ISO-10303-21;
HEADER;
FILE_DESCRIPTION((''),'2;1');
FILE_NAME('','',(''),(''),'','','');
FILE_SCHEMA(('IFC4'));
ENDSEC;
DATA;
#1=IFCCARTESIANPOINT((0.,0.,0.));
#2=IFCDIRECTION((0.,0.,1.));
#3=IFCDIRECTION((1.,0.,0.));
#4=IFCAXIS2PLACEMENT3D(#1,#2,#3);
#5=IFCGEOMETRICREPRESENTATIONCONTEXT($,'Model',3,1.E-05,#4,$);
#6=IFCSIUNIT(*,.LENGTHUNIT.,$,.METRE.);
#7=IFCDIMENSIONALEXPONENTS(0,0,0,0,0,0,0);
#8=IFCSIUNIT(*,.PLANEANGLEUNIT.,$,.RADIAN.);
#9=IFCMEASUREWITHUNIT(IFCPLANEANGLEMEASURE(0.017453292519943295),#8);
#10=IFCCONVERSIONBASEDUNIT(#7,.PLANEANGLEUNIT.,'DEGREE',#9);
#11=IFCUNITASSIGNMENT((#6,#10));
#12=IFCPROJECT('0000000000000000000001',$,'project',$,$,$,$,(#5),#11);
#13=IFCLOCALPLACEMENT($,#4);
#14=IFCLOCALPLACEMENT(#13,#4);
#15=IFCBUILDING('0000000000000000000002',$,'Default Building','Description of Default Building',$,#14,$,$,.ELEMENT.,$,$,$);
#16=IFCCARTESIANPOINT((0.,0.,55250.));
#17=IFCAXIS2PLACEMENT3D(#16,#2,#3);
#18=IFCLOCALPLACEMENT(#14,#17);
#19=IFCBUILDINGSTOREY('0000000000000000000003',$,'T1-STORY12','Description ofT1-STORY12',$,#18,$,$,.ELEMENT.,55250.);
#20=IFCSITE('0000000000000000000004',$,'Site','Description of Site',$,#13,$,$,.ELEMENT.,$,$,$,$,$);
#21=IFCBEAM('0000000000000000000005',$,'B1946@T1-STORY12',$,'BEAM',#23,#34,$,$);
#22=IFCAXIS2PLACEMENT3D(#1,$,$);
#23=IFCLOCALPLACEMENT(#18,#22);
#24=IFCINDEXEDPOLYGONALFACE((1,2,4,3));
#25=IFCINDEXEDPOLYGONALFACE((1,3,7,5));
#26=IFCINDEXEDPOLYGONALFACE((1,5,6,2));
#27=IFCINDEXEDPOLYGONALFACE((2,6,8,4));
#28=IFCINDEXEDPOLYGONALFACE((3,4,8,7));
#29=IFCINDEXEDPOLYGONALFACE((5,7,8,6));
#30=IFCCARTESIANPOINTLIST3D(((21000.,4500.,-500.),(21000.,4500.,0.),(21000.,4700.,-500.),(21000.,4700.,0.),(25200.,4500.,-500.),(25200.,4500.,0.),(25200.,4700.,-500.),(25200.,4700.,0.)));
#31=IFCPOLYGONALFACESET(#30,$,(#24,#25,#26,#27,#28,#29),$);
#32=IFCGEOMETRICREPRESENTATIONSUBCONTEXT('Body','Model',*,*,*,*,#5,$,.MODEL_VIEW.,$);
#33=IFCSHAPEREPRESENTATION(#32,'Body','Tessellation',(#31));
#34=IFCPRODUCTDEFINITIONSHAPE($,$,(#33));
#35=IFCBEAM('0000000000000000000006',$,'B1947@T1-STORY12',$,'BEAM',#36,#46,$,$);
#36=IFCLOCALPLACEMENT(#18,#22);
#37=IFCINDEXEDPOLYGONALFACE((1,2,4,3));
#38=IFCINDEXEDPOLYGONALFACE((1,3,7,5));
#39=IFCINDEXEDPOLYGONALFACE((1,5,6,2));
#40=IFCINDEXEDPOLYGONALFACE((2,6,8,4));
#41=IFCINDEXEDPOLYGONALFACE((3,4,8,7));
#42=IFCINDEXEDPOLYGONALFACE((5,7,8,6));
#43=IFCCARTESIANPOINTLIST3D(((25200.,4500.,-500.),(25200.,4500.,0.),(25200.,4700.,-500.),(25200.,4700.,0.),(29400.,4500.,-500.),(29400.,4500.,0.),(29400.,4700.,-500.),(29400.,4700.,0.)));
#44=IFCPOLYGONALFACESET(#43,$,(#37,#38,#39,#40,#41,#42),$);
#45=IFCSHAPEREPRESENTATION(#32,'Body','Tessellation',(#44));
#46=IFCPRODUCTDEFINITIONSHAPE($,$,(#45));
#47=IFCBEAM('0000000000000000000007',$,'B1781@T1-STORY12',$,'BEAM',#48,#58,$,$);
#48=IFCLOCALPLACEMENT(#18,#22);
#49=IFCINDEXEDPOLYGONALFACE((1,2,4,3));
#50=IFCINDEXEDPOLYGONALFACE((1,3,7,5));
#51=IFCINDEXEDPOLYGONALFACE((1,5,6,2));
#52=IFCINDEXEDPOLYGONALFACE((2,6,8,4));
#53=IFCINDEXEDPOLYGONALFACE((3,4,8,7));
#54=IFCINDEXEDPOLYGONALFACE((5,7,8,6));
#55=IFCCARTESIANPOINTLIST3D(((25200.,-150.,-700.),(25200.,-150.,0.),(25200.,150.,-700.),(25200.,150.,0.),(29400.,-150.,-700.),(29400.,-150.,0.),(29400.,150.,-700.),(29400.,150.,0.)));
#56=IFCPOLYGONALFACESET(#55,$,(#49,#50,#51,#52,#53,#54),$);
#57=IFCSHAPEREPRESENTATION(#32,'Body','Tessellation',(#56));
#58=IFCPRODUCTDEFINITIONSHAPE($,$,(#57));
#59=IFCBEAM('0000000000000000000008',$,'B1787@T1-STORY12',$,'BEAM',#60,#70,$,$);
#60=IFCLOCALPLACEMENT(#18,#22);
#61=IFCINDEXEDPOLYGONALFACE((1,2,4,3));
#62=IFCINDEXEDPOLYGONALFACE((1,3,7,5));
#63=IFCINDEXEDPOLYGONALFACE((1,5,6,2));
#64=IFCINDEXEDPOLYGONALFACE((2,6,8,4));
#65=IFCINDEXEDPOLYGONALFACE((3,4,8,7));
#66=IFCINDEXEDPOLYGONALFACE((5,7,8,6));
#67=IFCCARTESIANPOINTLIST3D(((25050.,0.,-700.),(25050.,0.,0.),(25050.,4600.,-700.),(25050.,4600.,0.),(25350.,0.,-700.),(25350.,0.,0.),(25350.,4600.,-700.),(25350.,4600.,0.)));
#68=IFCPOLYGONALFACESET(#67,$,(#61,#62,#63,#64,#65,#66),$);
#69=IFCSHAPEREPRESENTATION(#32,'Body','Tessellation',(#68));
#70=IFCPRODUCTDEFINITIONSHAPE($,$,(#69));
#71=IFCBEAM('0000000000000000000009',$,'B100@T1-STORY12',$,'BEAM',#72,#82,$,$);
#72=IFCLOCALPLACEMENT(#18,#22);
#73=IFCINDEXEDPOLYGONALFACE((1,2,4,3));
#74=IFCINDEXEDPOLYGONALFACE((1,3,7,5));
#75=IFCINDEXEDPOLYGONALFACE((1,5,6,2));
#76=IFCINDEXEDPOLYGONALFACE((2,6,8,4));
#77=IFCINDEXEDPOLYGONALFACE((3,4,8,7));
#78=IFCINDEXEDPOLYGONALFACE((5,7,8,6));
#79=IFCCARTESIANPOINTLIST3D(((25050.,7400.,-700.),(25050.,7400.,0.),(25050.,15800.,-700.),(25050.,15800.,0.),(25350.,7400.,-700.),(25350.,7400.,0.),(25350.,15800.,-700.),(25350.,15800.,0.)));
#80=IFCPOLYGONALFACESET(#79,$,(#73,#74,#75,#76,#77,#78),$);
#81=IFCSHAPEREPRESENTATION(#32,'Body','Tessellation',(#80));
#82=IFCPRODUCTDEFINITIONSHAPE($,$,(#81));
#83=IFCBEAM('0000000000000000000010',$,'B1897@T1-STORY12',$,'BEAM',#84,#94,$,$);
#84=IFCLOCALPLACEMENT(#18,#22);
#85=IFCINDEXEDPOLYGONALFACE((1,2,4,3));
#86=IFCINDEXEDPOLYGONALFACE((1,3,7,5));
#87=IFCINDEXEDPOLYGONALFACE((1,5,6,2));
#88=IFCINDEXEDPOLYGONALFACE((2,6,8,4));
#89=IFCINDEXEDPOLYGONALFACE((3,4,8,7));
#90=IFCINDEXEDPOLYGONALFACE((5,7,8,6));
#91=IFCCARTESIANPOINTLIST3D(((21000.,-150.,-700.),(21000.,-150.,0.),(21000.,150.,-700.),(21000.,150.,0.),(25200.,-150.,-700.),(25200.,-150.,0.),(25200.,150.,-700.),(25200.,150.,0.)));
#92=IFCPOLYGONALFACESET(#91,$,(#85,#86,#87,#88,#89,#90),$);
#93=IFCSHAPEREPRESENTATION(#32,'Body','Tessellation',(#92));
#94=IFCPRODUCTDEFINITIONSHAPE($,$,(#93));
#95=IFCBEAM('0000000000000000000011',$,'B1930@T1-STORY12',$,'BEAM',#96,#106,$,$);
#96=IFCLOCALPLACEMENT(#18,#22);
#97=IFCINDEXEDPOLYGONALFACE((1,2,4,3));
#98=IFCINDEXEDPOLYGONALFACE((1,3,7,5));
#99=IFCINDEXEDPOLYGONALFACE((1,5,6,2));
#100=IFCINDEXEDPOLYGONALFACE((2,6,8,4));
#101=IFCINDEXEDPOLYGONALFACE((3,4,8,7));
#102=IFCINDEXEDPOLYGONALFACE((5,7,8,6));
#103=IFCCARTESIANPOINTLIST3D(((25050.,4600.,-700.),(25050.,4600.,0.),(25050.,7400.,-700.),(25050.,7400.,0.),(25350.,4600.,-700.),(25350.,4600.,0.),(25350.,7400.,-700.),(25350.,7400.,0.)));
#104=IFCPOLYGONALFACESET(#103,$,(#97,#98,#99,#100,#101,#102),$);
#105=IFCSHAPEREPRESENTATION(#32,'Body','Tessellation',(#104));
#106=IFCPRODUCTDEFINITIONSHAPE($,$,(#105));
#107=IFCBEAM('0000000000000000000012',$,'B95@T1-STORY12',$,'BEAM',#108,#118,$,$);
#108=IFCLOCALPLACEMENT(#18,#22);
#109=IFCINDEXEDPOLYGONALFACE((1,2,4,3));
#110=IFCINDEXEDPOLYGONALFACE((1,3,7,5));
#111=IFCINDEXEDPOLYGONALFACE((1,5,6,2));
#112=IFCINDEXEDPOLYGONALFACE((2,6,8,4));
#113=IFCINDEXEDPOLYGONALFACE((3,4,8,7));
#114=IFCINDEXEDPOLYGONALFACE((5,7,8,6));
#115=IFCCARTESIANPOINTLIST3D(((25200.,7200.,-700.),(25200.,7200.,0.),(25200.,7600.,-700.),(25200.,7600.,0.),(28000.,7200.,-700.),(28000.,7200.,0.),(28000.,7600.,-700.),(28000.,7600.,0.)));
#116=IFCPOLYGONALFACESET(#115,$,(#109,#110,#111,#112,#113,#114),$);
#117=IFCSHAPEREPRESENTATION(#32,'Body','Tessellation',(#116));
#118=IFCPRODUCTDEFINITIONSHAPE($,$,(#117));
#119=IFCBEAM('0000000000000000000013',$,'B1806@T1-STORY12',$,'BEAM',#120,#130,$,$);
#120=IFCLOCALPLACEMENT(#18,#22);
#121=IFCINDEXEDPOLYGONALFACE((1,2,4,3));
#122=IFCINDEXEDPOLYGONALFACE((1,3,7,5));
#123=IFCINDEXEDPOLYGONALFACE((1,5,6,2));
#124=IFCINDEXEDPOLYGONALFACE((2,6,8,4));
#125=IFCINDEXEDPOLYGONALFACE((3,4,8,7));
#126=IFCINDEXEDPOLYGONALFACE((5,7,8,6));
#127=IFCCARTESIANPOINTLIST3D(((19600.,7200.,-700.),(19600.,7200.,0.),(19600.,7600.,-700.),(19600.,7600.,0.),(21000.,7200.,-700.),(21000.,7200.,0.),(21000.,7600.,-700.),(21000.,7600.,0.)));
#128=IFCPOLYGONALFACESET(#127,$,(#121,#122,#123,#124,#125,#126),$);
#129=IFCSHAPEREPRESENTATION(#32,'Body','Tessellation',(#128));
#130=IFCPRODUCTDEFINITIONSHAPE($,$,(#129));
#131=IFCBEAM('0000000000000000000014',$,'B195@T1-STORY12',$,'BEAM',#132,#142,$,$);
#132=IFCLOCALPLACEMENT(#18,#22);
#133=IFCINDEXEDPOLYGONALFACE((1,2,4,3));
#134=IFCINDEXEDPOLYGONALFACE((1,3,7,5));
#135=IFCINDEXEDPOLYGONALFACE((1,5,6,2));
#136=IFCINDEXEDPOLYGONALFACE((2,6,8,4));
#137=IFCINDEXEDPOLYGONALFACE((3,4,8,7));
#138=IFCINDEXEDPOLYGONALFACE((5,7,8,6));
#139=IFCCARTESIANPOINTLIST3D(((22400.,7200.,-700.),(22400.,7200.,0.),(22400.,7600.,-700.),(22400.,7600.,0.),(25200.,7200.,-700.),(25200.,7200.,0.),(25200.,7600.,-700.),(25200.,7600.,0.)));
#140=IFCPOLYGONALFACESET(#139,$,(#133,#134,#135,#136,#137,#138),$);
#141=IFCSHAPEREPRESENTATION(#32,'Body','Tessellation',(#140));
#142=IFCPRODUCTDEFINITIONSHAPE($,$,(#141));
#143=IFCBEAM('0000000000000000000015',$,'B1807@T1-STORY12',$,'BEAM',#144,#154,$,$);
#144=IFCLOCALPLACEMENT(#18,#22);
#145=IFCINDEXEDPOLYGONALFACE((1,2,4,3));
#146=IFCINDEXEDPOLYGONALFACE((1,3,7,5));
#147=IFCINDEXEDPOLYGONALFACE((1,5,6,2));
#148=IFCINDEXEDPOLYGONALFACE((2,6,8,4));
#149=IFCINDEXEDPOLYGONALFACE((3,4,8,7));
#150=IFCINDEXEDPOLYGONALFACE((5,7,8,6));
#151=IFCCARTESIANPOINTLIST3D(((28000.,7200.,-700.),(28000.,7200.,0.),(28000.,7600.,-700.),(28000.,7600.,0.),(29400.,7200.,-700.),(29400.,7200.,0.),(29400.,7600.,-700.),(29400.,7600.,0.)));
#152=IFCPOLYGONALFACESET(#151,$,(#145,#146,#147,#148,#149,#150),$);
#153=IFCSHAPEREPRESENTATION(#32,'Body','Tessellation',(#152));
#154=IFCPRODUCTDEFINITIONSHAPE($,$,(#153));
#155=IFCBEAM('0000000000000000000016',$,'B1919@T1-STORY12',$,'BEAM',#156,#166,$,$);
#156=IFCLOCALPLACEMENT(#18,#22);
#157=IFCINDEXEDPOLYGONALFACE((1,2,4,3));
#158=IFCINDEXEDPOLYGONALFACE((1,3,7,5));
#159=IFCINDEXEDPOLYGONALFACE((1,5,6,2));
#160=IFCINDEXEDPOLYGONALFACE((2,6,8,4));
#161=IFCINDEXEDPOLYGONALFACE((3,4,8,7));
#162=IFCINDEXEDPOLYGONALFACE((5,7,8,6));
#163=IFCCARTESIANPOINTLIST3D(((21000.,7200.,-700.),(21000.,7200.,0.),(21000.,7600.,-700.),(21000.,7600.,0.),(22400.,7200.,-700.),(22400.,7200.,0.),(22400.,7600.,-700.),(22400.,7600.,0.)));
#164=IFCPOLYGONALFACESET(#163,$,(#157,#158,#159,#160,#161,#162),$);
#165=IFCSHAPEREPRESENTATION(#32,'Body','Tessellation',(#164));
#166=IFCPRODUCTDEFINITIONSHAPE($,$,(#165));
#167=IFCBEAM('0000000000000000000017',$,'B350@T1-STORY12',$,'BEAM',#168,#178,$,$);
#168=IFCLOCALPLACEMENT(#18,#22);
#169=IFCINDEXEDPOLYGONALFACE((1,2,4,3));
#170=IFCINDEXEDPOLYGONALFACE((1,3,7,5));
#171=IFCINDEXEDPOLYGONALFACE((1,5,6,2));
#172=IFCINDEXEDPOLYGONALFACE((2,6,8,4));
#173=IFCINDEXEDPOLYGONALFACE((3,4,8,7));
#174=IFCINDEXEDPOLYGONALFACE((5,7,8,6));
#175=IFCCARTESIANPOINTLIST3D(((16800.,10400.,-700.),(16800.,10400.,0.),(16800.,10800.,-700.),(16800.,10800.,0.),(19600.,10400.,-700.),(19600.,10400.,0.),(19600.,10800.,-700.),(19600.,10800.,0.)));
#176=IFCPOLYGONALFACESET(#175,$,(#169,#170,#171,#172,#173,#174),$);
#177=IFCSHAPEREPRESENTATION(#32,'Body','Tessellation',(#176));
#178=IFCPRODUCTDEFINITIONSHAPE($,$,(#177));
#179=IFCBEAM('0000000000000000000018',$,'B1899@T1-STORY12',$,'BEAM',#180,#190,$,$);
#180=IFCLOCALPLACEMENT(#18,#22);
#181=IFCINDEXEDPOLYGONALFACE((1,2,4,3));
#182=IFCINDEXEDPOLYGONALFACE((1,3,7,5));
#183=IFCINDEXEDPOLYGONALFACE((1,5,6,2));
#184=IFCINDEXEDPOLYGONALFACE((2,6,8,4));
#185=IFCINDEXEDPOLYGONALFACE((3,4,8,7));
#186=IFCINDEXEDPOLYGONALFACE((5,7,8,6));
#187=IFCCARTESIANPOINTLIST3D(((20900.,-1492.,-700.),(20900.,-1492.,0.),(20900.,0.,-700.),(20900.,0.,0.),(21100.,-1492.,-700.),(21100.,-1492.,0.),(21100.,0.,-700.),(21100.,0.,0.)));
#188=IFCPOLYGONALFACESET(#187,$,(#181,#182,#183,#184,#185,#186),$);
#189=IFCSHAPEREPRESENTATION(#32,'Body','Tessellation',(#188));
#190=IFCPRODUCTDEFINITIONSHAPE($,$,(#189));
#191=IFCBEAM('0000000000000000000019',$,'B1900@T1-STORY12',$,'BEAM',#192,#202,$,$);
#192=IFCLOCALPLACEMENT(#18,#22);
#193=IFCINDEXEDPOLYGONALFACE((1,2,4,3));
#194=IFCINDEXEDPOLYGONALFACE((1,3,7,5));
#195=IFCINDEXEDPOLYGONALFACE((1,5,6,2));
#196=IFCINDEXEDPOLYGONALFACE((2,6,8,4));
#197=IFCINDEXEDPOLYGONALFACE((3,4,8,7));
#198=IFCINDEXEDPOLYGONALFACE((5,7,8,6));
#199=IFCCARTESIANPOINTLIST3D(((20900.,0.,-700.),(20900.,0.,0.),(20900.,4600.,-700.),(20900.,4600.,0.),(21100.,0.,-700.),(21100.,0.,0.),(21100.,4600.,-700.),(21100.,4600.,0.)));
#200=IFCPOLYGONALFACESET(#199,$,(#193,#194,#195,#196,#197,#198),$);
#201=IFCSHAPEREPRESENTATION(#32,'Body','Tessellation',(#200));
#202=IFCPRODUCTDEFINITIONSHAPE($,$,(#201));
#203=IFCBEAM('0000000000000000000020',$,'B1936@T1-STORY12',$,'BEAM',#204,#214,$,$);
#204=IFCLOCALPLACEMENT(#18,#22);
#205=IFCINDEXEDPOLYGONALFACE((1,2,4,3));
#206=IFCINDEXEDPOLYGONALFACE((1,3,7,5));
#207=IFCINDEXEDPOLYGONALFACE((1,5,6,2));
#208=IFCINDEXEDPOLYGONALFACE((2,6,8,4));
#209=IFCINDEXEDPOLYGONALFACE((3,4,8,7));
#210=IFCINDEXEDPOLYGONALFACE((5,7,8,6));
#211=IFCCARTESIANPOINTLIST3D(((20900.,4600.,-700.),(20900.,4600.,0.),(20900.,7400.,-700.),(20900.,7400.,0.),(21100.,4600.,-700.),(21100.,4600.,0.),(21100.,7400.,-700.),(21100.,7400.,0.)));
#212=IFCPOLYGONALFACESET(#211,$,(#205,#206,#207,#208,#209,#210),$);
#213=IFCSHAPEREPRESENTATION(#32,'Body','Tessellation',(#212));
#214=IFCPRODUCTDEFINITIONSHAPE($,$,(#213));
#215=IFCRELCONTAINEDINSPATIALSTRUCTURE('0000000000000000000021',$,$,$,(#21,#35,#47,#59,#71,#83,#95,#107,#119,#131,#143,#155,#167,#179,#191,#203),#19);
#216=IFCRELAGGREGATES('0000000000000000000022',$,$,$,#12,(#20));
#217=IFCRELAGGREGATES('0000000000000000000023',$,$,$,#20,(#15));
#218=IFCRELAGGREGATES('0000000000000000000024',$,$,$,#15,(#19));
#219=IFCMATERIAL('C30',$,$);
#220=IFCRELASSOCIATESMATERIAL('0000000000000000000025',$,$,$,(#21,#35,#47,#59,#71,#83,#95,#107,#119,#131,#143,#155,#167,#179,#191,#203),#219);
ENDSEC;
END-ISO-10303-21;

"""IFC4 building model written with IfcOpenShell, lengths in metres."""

from ifc_helpers import new_model, entity, si_unit, converted_unit, frame, origin_with_axes, place, context, subcontext, project, spatial, rectangle, extrude, material, element, save


model = new_model("IFC4")

# Units and contexts
model_context = context("Model", 3, precision=1e-05, world=origin_with_axes())
body_context = subcontext(model_context, "Body", "Model", "MODEL_VIEW")
ifc_project = project(units=[si_unit("LENGTHUNIT", "METRE"), converted_unit("PLANEANGLEUNIT", "DEGREE", entity("IfcPlaneAngleMeasure", 0.017453292519943295), si_unit("PLANEANGLEUNIT", "RADIAN"), dimensions=[0, 0, 0, 0, 0, 0, 0])], contexts=[model_context])

# Site, building, storey
site_placement = place(None, origin_with_axes())
site = spatial("IfcSite", under=ifc_project, at=site_placement, Name="Site", Description="Description of Site", CompositionType="ELEMENT")
building_placement = place(site_placement, origin_with_axes())
building = spatial("IfcBuilding", under=site, at=building_placement, Name="Default Building", Description="Description of Default Building", CompositionType="ELEMENT")
storey_placement = place(building_placement, frame((0.0, 0.0, 55250.0), z_axis=(0.0, 0.0, 1.0), x_axis=(1.0, 0.0, 0.0)))
storey = spatial("IfcBuildingStorey", under=building, at=storey_placement, Name="T1-STORY12", Description="Description ofT1-STORY12", CompositionType="ELEMENT", Elevation=55250.0)

# Beams
ifc_material_1 = material(Name="C30")
for number, where, z_axis, x_axis, name in (
    (1, (21000.0, 4600.0, -250.0), (1.0, 0.0, 0.0), (0.0, 1.0, 0.0), "B1946@T1-STORY12"),
    (2, (25200.0, 4600.0, -250.0), (1.0, 0.0, 0.0), (0.0, 1.0, 0.0), "B1947@T1-STORY12"),
):
    element("IfcBeam", number, at=place(storey_placement, frame(where, z_axis=z_axis, x_axis=x_axis)), inside=storey, material=ifc_material_1, Name=name, ObjectType="BEAM", context=body_context, shape_type="SweptSolid", body=[
        extrude(rectangle(XDim=200.0, YDim=500.0), origin_with_axes(), (0.0, 0.0, 1.0), 4200.0),
    ])
beam_1_placement = place(storey_placement, frame((25200.0, 0.0, -350.0), z_axis=(1.0, 0.0, 0.0), x_axis=(0.0, 1.0, 0.0)))
element("IfcBeam", 3, at=beam_1_placement, inside=storey, material=ifc_material_1, Name="B1781@T1-STORY12", ObjectType="BEAM", context=body_context, shape_type="SweptSolid", body=[
    extrude(rectangle(XDim=300.0, YDim=700.0), origin_with_axes(), (0.0, 0.0, 1.0), 4200.0),
])
beam_2_placement = place(storey_placement, frame((25200.0, 0.0, -350.0), z_axis=(0.0, 1.0, 0.0), x_axis=(-1.0, 0.0, 0.0)))
element("IfcBeam", 4, at=beam_2_placement, inside=storey, material=ifc_material_1, Name="B1787@T1-STORY12", ObjectType="BEAM", context=body_context, shape_type="SweptSolid", body=[
    extrude(rectangle(XDim=300.0, YDim=700.0), origin_with_axes(), (0.0, 0.0, 1.0), 4600.0),
])
beam_3_placement = place(storey_placement, frame((25200.0, 7400.0, -350.0), z_axis=(0.0, 1.0, 0.0), x_axis=(-1.0, 0.0, 0.0)))
element("IfcBeam", 5, at=beam_3_placement, inside=storey, material=ifc_material_1, Name="B100@T1-STORY12", ObjectType="BEAM", context=body_context, shape_type="SweptSolid", body=[
    extrude(rectangle(XDim=300.0, YDim=700.0), origin_with_axes(), (0.0, 0.0, 1.0), 8400.0),
])
beam_4_placement = place(storey_placement, frame((21000.0, 0.0, -350.0), z_axis=(1.0, 0.0, 0.0), x_axis=(0.0, 1.0, 0.0)))
element("IfcBeam", 6, at=beam_4_placement, inside=storey, material=ifc_material_1, Name="B1897@T1-STORY12", ObjectType="BEAM", context=body_context, shape_type="SweptSolid", body=[
    extrude(rectangle(XDim=300.0, YDim=700.0), origin_with_axes(), (0.0, 0.0, 1.0), 4200.0),
])
beam_5_placement = place(storey_placement, frame((25200.0, 4600.0, -350.0), z_axis=(0.0, 1.0, 0.0), x_axis=(-1.0, 0.0, 0.0)))
element("IfcBeam", 7, at=beam_5_placement, inside=storey, material=ifc_material_1, Name="B1930@T1-STORY12", ObjectType="BEAM", context=body_context, shape_type="SweptSolid", body=[
    extrude(rectangle(XDim=300.0, YDim=700.0), origin_with_axes(), (0.0, 0.0, 1.0), 2800.0),
])
beam_6_placement = place(storey_placement, frame((25200.0, 7400.0, -350.0), z_axis=(1.0, 0.0, 0.0), x_axis=(0.0, 1.0, 0.0)))
element("IfcBeam", 8, at=beam_6_placement, inside=storey, material=ifc_material_1, Name="B95@T1-STORY12", ObjectType="BEAM", context=body_context, shape_type="SweptSolid", body=[
    extrude(rectangle(XDim=400.0, YDim=700.0), origin_with_axes(), (0.0, 0.0, 1.0), 2800.0),
])
beam_7_placement = place(storey_placement, frame((19600.0, 7400.0, -350.0), z_axis=(1.0, 0.0, 0.0), x_axis=(0.0, 1.0, 0.0)))
element("IfcBeam", 9, at=beam_7_placement, inside=storey, material=ifc_material_1, Name="B1806@T1-STORY12", ObjectType="BEAM", context=body_context, shape_type="SweptSolid", body=[
    extrude(rectangle(XDim=400.0, YDim=700.0), origin_with_axes(), (0.0, 0.0, 1.0), 1400.0),
])
beam_8_placement = place(storey_placement, frame((22400.0, 7400.0, -350.0), z_axis=(1.0, 0.0, 0.0), x_axis=(0.0, 1.0, 0.0)))
element("IfcBeam", 10, at=beam_8_placement, inside=storey, material=ifc_material_1, Name="B195@T1-STORY12", ObjectType="BEAM", context=body_context, shape_type="SweptSolid", body=[
    extrude(rectangle(XDim=400.0, YDim=700.0), origin_with_axes(), (0.0, 0.0, 1.0), 2800.0),
])
for number, where, z_axis, x_axis, name in (
    (11, (28000.0, 7400.0, -350.0), (1.0, 0.0, 0.0), (0.0, 1.0, 0.0), "B1807@T1-STORY12"),
    (12, (21000.0, 7400.0, -350.0), (1.0, 0.0, 0.0), (0.0, 1.0, 0.0), "B1919@T1-STORY12"),
):
    element("IfcBeam", number, at=place(storey_placement, frame(where, z_axis=z_axis, x_axis=x_axis)), inside=storey, material=ifc_material_1, Name=name, ObjectType="BEAM", context=body_context, shape_type="SweptSolid", body=[
        extrude(rectangle(XDim=400.0, YDim=700.0), origin_with_axes(), (0.0, 0.0, 1.0), 1400.0),
    ])
beam_9_placement = place(storey_placement, frame((16800.0, 10600.0, -350.0), z_axis=(1.0, 0.0, 0.0), x_axis=(0.0, 1.0, 0.0)))
element("IfcBeam", 13, at=beam_9_placement, inside=storey, material=ifc_material_1, Name="B350@T1-STORY12", ObjectType="BEAM", context=body_context, shape_type="SweptSolid", body=[
    extrude(rectangle(XDim=400.0, YDim=700.0), origin_with_axes(), (0.0, 0.0, 1.0), 2800.0),
])
beam_10_placement = place(storey_placement, frame((21000.0, -1492.0, -350.0), z_axis=(0.0, 1.0, 0.0), x_axis=(-1.0, 0.0, 0.0)))
element("IfcBeam", 14, at=beam_10_placement, inside=storey, material=ifc_material_1, Name="B1899@T1-STORY12", ObjectType="BEAM", context=body_context, shape_type="SweptSolid", body=[
    extrude(rectangle(XDim=200.0, YDim=700.0), origin_with_axes(), (0.0, 0.0, 1.0), 1492.0),
])
beam_11_placement = place(storey_placement, frame((21000.0, 0.0, -350.0), z_axis=(0.0, 1.0, 0.0), x_axis=(-1.0, 0.0, 0.0)))
element("IfcBeam", 15, at=beam_11_placement, inside=storey, material=ifc_material_1, Name="B1900@T1-STORY12", ObjectType="BEAM", context=body_context, shape_type="SweptSolid", body=[
    extrude(rectangle(XDim=200.0, YDim=700.0), origin_with_axes(), (0.0, 0.0, 1.0), 4600.0),
])
beam_12_placement = place(storey_placement, frame((21000.0, 4600.0, -350.0), z_axis=(0.0, 1.0, 0.0), x_axis=(-1.0, 0.0, 0.0)))
element("IfcBeam", 16, at=beam_12_placement, inside=storey, material=ifc_material_1, Name="B1936@T1-STORY12", ObjectType="BEAM", context=body_context, shape_type="SweptSolid", body=[
    extrude(rectangle(XDim=200.0, YDim=700.0), origin_with_axes(), (0.0, 0.0, 1.0), 2800.0),
])

save(model, "model.ifc")
